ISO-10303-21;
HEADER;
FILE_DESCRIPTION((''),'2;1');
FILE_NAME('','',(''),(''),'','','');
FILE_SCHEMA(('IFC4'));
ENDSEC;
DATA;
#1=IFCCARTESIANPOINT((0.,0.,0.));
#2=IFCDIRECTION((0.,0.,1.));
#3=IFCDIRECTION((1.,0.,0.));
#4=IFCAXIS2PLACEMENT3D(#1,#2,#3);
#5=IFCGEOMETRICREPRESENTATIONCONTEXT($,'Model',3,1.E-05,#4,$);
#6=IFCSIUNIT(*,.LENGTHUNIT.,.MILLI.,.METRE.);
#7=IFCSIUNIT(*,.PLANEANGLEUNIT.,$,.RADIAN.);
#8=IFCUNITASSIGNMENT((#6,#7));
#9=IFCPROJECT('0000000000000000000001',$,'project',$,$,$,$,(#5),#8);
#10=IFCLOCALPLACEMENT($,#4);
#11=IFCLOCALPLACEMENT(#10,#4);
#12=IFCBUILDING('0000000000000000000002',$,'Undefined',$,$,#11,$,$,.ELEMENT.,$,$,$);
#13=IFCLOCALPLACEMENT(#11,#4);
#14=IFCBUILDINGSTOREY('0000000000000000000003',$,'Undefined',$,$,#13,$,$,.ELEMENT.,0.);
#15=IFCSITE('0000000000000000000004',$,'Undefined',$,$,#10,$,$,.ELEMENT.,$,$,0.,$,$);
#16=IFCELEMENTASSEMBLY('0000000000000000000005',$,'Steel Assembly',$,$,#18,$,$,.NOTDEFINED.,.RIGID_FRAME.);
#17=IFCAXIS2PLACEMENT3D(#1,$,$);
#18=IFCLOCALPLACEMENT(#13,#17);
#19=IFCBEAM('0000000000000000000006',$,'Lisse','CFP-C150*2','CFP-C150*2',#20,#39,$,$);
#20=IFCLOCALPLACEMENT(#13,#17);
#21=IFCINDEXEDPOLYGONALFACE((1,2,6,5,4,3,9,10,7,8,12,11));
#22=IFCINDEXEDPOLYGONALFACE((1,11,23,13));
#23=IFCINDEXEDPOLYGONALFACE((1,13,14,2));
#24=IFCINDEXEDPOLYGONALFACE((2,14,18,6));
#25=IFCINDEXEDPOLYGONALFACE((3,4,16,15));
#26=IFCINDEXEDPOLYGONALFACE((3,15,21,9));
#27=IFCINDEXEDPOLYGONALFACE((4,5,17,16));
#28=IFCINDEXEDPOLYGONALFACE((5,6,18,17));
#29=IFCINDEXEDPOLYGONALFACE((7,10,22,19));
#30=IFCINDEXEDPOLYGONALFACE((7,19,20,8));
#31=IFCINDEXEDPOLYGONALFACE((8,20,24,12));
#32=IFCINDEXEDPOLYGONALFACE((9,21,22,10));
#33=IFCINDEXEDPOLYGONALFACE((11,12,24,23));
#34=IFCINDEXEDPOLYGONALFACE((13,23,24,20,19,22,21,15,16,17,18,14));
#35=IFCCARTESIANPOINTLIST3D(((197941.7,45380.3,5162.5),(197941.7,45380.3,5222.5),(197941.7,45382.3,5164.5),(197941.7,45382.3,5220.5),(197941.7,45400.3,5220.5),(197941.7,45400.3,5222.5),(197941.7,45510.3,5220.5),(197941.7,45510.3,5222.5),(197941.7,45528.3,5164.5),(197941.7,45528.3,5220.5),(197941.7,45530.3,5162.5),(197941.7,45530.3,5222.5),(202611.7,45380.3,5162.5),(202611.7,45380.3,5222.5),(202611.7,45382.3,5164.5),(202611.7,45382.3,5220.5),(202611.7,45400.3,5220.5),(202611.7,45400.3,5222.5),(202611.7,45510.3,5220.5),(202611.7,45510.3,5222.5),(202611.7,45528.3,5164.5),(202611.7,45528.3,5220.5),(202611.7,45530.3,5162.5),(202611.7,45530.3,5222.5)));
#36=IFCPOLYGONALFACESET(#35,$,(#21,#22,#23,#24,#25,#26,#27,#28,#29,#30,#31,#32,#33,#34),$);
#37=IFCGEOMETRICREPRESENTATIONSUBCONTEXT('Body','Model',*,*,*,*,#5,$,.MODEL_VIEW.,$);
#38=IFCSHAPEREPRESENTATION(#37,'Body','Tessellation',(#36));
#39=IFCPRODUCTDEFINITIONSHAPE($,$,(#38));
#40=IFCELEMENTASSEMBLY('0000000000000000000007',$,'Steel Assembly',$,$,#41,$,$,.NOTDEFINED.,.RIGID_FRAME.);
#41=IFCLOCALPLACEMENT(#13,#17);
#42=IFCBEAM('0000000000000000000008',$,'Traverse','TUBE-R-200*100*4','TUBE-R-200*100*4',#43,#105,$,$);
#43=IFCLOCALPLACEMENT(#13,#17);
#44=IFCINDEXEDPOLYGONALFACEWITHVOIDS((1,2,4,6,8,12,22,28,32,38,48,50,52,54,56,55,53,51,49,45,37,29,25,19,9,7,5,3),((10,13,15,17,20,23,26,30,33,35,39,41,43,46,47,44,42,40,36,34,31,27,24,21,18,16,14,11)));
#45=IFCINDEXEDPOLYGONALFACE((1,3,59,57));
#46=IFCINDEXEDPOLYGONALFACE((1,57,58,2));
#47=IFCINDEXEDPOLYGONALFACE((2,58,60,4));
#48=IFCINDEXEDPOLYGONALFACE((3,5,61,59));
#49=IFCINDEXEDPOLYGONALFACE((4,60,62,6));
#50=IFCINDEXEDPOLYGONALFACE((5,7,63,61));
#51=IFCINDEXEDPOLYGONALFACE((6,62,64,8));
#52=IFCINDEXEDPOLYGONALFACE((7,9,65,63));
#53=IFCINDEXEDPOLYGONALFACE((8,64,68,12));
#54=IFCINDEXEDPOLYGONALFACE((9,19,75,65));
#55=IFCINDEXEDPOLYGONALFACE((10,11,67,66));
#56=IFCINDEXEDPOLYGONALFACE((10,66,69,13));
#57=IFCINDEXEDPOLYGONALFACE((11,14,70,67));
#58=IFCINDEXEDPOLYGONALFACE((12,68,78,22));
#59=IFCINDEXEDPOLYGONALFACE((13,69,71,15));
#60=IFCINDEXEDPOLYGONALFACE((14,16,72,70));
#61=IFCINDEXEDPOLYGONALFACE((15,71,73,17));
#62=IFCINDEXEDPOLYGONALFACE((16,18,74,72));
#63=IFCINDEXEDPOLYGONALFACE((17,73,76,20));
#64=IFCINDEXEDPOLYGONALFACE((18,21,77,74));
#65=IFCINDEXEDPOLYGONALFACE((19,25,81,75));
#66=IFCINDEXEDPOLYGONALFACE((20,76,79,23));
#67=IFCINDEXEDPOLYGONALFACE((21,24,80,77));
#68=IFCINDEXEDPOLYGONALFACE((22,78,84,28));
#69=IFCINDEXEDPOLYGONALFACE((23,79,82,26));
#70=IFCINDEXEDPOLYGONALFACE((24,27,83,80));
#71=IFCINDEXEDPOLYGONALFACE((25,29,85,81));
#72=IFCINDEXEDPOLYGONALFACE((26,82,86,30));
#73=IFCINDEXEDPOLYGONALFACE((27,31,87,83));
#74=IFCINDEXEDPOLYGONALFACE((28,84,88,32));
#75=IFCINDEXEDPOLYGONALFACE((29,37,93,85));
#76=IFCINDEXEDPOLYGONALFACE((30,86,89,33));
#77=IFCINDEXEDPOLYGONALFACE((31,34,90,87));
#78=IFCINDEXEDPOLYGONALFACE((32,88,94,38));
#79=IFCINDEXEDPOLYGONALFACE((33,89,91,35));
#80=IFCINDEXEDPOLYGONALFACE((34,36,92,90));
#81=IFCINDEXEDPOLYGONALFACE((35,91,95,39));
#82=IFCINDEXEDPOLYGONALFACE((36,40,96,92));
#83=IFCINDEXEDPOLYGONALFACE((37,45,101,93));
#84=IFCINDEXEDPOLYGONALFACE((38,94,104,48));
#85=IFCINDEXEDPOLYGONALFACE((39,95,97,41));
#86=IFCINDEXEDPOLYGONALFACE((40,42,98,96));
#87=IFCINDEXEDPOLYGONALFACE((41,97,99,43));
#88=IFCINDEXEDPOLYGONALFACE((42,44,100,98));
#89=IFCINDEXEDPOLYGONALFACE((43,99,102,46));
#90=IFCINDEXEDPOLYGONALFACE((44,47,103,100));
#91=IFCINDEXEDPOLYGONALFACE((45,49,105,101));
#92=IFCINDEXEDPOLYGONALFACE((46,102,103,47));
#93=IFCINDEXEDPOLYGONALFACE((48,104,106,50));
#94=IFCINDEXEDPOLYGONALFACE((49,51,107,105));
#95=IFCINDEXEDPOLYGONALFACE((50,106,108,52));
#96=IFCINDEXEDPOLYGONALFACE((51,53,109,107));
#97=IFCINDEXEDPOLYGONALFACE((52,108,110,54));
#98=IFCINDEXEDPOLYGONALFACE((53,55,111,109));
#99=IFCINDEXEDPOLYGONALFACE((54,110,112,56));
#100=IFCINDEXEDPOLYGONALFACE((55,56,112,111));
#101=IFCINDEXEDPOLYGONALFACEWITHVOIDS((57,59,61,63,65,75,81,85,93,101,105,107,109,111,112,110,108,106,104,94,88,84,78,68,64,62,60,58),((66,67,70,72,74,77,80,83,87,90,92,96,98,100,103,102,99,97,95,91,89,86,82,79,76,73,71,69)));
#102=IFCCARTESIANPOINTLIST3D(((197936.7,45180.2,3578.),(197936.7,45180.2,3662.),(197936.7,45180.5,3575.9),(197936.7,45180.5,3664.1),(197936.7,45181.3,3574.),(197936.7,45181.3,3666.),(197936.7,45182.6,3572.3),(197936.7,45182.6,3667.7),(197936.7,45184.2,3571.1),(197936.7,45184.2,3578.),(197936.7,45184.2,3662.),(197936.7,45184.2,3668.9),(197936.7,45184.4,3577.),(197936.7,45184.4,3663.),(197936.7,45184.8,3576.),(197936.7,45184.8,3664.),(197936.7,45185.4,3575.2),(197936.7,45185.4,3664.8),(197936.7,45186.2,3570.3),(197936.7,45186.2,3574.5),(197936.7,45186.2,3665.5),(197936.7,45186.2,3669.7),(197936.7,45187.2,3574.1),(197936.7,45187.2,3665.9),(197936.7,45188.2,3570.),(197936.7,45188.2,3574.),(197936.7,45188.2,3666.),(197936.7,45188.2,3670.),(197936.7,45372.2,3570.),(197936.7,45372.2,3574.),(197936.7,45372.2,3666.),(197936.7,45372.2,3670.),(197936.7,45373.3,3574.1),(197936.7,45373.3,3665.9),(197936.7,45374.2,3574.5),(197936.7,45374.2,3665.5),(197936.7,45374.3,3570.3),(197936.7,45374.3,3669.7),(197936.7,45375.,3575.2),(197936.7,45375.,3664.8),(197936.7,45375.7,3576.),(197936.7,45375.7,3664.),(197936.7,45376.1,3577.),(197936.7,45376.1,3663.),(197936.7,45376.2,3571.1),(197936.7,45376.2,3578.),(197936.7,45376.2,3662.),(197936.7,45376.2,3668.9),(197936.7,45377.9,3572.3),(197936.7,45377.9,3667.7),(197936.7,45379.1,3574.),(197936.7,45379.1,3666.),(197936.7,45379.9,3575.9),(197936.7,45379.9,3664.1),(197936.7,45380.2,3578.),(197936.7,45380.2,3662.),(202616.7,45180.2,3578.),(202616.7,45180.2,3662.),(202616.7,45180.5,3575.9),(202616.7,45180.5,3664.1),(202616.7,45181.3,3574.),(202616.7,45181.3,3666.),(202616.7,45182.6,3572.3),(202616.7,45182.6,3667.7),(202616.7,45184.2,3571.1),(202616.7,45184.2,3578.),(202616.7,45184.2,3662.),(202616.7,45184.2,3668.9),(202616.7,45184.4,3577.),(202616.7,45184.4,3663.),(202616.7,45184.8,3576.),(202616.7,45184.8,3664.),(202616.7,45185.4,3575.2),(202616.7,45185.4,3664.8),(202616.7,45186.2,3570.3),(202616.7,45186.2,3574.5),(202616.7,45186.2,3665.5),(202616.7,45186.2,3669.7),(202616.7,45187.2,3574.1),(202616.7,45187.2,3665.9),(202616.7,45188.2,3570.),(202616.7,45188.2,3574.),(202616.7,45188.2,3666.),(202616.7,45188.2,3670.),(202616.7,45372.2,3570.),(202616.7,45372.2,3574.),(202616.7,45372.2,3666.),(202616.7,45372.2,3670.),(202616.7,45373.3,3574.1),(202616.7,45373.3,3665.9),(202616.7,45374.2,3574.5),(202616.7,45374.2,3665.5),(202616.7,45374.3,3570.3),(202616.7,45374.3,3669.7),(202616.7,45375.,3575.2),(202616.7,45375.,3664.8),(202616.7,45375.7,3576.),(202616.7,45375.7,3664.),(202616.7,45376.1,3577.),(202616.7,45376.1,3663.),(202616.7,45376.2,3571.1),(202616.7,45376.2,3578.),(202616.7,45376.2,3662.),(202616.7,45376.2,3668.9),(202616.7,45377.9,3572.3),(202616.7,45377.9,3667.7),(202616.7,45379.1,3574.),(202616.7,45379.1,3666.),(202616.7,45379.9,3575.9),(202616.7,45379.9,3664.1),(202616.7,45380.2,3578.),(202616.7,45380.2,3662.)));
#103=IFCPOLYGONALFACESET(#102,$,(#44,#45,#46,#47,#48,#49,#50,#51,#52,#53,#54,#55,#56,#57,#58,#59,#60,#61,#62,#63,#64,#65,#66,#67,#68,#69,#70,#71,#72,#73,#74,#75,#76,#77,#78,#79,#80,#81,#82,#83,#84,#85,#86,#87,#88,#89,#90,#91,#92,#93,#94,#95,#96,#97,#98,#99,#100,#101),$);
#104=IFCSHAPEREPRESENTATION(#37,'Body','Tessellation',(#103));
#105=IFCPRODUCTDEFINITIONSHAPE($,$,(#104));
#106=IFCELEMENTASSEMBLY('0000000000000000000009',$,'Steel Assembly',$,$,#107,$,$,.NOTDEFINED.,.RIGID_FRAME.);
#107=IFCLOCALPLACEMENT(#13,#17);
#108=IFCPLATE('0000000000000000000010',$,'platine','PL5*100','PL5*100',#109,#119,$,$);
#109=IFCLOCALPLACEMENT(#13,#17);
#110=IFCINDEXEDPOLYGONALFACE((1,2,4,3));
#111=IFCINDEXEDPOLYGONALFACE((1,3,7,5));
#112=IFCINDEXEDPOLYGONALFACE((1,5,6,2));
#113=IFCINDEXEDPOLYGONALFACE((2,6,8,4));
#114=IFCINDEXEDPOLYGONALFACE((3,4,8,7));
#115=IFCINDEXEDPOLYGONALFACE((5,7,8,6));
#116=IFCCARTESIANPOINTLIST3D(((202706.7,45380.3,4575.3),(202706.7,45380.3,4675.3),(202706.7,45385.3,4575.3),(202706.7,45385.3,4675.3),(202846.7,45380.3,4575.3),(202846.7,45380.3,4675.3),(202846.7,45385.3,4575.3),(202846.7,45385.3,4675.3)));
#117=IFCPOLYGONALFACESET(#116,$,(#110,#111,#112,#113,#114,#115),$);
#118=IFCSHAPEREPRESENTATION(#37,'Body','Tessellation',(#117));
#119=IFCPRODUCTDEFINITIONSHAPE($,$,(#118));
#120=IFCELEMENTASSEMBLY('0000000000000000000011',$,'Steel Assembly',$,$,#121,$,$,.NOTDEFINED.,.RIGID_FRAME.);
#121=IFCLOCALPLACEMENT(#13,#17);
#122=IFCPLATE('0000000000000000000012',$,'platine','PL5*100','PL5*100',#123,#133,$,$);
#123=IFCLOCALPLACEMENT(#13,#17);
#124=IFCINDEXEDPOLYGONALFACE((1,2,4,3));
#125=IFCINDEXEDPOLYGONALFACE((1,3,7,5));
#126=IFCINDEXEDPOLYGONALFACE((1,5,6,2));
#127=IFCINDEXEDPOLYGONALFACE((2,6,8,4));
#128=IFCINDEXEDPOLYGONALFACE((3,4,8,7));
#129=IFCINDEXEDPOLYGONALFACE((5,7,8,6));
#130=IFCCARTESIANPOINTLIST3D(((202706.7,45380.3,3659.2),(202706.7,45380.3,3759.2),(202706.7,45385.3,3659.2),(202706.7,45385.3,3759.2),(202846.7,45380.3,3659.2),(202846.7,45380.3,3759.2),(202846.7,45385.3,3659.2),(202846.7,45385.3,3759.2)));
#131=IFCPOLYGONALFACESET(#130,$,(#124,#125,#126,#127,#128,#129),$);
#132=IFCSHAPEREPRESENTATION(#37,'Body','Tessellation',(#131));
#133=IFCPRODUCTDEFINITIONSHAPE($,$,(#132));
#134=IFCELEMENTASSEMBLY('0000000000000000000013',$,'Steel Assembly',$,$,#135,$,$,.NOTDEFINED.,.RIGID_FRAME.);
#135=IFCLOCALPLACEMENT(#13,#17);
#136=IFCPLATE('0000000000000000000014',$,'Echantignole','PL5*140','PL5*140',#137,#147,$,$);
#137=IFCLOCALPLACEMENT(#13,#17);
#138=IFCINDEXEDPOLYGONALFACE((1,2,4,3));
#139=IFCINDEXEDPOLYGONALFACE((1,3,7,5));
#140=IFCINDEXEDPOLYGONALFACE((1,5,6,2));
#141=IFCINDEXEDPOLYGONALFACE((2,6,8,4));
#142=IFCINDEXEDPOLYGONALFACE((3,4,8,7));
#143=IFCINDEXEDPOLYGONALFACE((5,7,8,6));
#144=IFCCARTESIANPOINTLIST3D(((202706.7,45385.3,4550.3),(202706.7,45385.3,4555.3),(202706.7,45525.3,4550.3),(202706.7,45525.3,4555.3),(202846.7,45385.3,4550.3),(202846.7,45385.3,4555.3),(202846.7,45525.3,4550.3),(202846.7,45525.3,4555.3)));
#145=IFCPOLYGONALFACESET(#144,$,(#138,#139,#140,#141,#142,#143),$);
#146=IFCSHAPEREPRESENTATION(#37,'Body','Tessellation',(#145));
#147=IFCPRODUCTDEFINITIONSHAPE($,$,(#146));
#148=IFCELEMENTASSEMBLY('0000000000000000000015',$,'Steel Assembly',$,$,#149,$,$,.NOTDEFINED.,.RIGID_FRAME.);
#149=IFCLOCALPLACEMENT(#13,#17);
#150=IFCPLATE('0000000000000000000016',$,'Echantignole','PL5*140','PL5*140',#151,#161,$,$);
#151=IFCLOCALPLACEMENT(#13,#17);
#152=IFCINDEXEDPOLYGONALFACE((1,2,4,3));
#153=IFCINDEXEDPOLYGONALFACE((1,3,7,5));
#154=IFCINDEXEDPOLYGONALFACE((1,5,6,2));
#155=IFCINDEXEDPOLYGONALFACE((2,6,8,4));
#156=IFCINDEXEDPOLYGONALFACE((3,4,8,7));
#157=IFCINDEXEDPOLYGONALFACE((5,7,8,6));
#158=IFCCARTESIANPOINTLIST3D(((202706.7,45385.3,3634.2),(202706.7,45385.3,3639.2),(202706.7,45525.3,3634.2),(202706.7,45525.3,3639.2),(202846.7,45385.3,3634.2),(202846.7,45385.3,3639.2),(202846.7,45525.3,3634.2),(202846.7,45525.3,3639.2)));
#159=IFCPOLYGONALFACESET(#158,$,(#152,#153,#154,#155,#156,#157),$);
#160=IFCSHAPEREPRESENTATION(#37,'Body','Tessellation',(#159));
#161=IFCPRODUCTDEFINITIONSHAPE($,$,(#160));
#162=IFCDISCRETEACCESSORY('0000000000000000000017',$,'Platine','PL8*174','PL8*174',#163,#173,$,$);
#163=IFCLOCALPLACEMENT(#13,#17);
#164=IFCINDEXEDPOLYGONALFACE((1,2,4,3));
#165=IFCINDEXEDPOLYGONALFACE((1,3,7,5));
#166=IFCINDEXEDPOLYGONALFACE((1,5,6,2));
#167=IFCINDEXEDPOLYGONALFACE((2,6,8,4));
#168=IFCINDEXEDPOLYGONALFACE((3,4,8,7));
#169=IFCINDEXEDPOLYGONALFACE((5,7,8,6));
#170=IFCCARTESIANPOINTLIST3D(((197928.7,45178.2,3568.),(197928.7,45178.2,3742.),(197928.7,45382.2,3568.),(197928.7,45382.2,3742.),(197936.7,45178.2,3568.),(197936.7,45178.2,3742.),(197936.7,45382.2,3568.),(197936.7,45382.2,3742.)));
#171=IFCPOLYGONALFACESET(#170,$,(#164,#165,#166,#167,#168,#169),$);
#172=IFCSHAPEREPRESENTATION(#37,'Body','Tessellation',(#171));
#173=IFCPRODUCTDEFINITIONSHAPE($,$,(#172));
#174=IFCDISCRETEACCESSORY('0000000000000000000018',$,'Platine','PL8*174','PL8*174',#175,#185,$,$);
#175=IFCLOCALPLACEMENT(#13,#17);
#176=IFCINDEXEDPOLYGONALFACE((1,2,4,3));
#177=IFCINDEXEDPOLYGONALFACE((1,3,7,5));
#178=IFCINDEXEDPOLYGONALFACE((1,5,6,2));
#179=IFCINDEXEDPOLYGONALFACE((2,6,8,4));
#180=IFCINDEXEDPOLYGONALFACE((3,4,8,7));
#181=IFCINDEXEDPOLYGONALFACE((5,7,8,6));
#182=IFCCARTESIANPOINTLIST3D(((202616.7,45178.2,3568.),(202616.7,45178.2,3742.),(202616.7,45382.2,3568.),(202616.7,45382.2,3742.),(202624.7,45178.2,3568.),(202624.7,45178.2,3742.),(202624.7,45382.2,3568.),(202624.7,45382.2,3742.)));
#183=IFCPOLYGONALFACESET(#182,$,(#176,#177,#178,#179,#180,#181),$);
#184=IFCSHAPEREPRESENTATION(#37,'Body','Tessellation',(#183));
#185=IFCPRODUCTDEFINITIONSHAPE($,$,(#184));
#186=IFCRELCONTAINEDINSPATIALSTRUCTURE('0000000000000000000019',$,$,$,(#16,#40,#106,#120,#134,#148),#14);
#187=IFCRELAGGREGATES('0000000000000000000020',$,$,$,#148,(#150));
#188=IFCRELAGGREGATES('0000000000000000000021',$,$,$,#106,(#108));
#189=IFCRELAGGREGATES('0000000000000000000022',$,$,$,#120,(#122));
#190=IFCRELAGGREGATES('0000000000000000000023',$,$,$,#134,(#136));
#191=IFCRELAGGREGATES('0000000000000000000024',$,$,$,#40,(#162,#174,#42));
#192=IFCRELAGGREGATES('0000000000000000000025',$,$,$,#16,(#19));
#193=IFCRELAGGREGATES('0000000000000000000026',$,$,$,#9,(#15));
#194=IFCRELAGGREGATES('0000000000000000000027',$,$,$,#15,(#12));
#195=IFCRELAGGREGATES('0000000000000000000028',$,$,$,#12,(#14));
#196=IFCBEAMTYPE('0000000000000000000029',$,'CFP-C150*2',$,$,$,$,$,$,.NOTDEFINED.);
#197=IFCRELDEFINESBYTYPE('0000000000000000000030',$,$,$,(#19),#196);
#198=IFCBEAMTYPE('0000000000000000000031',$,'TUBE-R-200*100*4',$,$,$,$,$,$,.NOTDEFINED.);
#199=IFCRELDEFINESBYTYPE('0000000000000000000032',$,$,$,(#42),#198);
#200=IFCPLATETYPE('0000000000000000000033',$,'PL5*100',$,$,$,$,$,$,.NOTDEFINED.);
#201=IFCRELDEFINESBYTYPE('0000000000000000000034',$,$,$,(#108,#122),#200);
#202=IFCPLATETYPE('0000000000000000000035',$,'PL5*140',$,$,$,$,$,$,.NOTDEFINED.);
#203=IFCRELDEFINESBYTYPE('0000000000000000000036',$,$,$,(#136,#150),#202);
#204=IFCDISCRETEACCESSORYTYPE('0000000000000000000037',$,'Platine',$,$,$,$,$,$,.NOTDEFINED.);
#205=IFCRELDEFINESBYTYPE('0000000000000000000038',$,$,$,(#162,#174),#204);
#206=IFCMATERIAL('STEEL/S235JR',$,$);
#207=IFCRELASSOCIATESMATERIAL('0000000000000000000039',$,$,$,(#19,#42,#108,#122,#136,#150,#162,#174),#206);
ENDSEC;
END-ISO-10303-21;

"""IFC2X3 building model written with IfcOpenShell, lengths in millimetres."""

from ifc_helpers import new_model, si_unit, frame, origin_with_axes, origin_2d_with_axis, place, context, subcontext, project, spatial, polyline, hollow_rectangle, c_section, outline, extrude, material, type_object, element, aggregate, save


model = new_model("IFC2X3")

# Units and contexts
model_context = context("Model", 3, precision=1e-05, world=origin_with_axes())
body_context = subcontext(model_context, "Body", "Model", "MODEL_VIEW")
ifc_project = project(units=[si_unit("LENGTHUNIT", "METRE", prefix="MILLI"), si_unit("PLANEANGLEUNIT", "RADIAN")], contexts=[model_context])

# Site, building, storey
site_placement = place(None, origin_with_axes())
site = spatial("IfcSite", under=ifc_project, at=site_placement, Name="Undefined", CompositionType="ELEMENT", RefElevation=0.0)
building_placement = place(site_placement, origin_with_axes())
building = spatial("IfcBuilding", under=site, at=building_placement, Name="Undefined", CompositionType="ELEMENT")
storey_placement = place(building_placement, origin_with_axes())
storey = spatial("IfcBuildingStorey", under=building, at=storey_placement, Name="Undefined", CompositionType="ELEMENT", Elevation=0.0)

# Element assemblies, beams
assembly_1_placement = place(storey_placement, origin_with_axes())
assembly_1 = element("IfcElementAssembly", 1, at=assembly_1_placement, inside=storey, Name="Steel Assembly", AssemblyPlace="NOTDEFINED", PredefinedType="RIGID_FRAME")
ifc_material_1 = material(Name="STEEL/S235JR")
beam_type_1 = type_object("IfcBeamType", Name="CFP-C150*2", PredefinedType="NOTDEFINED")
beam_1_placement = place(assembly_1_placement, frame((202776.7, 45455.3, 5192.5), z_axis=(0.0, -1.0, 0.0), x_axis=(-1.0, 0.0, 0.0)))
beam_1 = element("IfcBeam", 2, at=beam_1_placement, type_object=beam_type_1, material=ifc_material_1, Name="Lisse", Description="CFP-C150*2", ObjectType="CFP-C150*2", context=body_context, shape_type="SweptSolid", body=[
    extrude(c_section(Depth=150.0, Width=60.0, WallThickness=2.0, Girth=20.0, at=origin_2d_with_axis()), frame((4835.0, 0.0, 0.0), z_axis=(-1.0, 0.0, 0.0), x_axis=(0.0, -1.0, 0.0)), (0.0, 0.0, 1.0), 4670.0),
])
assembly_2_placement = place(storey_placement, origin_with_axes())
assembly_2 = element("IfcElementAssembly", 3, at=assembly_2_placement, inside=storey, Name="Steel Assembly", AssemblyPlace="NOTDEFINED", PredefinedType="RIGID_FRAME")
beam_type_2 = type_object("IfcBeamType", Name="TUBE-R-200*100*4", PredefinedType="NOTDEFINED")
beam_2_placement = place(assembly_2_placement, frame((202626.7, 45280.2, 3620.0), z_axis=(0.0, -1.0, 0.0), x_axis=(-1.0, 0.0, 0.0)))
beam_2 = element("IfcBeam", 4, at=beam_2_placement, type_object=beam_type_2, material=ifc_material_1, Name="Traverse", Description="TUBE-R-200*100*4", ObjectType="TUBE-R-200*100*4", context=body_context, shape_type="SweptSolid", body=[
    extrude(hollow_rectangle(XDim=100.0, YDim=200.0, WallThickness=4.0, InnerFilletRadius=4.0, OuterFilletRadius=8.0, at=origin_2d_with_axis()), frame((4690.0, 0.0, 0.0), z_axis=(-1.0, 0.0, 0.0), x_axis=(0.0, -1.0, 0.0)), (0.0, 0.0, 1.0), 4680.0),
])

# Element assemblies, plates
assembly_3_placement = place(storey_placement, origin_with_axes())
assembly_3 = element("IfcElementAssembly", 5, at=assembly_3_placement, inside=storey, Name="Steel Assembly", AssemblyPlace="NOTDEFINED", PredefinedType="RIGID_FRAME")
plate_type_1 = type_object("IfcPlateType", Name="PL5*100", PredefinedType="NOTDEFINED")
plate_1_placement = place(assembly_3_placement, frame((202706.7, 45382.8, 4675.3), z_axis=(0.0, 1.0, 0.0), x_axis=(1.0, 0.0, 0.0)))
plate_1 = element("IfcPlate", 6, at=plate_1_placement, type_object=plate_type_1, material=ifc_material_1, Name="platine", Description="PL5*100", ObjectType="PL5*100", context=body_context, shape_type="SweptSolid", body=[
    extrude(outline(polyline([(0.0, 0.0), (140.0, 0.0), (140.0, 100.0), (0.0, 100.0), (0.0, 0.0)])), frame((0.0, 0.0, -2.5), z_axis=(0.0, 0.0, 1.0), x_axis=(1.0, 0.0, 0.0)), (0.0, 0.0, 1.0), 5.0),
])
assembly_4_placement = place(storey_placement, origin_with_axes())
assembly_4 = element("IfcElementAssembly", 7, at=assembly_4_placement, inside=storey, Name="Steel Assembly", AssemblyPlace="NOTDEFINED", PredefinedType="RIGID_FRAME")
plate_2_placement = place(assembly_4_placement, frame((202706.7, 45382.8, 3759.2), z_axis=(0.0, 1.0, 0.0), x_axis=(1.0, 0.0, 0.0)))
plate_2 = element("IfcPlate", 8, at=plate_2_placement, type_object=plate_type_1, material=ifc_material_1, Name="platine", Description="PL5*100", ObjectType="PL5*100", context=body_context, shape_type="SweptSolid", body=[
    extrude(outline(polyline([(0.0, 0.0), (140.0, 0.0), (140.0, 100.0), (0.0, 100.0), (0.0, 0.0)])), frame((0.0, 0.0, -2.5), z_axis=(0.0, 0.0, 1.0), x_axis=(1.0, 0.0, 0.0)), (0.0, 0.0, 1.0), 5.0),
])
assembly_5_placement = place(storey_placement, origin_with_axes())
assembly_5 = element("IfcElementAssembly", 9, at=assembly_5_placement, inside=storey, Name="Steel Assembly", AssemblyPlace="NOTDEFINED", PredefinedType="RIGID_FRAME")
plate_type_2 = type_object("IfcPlateType", Name="PL5*140", PredefinedType="NOTDEFINED")
plate_3_placement = place(assembly_5_placement, frame((202706.7, 45385.3, 4552.8), z_axis=(0.0, 0.0, 1.0), x_axis=(1.0, 0.0, 0.0)))
plate_3 = element("IfcPlate", 10, at=plate_3_placement, type_object=plate_type_2, material=ifc_material_1, Name="Echantignole", Description="PL5*140", ObjectType="PL5*140", context=body_context, shape_type="SweptSolid", body=[
    extrude(outline(polyline([(0.0, 0.0), (140.0, 0.0), (140.0, 140.0), (0.0, 140.0), (0.0, 0.0)])), frame((0.0, 0.0, -2.5), z_axis=(0.0, 0.0, 1.0), x_axis=(1.0, 0.0, 0.0)), (0.0, 0.0, 1.0), 5.0),
])
assembly_6_placement = place(storey_placement, origin_with_axes())
assembly_6 = element("IfcElementAssembly", 11, at=assembly_6_placement, inside=storey, Name="Steel Assembly", AssemblyPlace="NOTDEFINED", PredefinedType="RIGID_FRAME")
plate_4_placement = place(assembly_6_placement, frame((202706.7, 45385.3, 3636.7), z_axis=(0.0, 0.0, 1.0), x_axis=(1.0, 0.0, 0.0)))
plate_4 = element("IfcPlate", 12, at=plate_4_placement, type_object=plate_type_2, material=ifc_material_1, Name="Echantignole", Description="PL5*140", ObjectType="PL5*140", context=body_context, shape_type="SweptSolid", body=[
    extrude(outline(polyline([(0.0, 0.0), (140.0, 0.0), (140.0, 140.0), (0.0, 140.0), (0.0, 0.0)])), frame((0.0, 0.0, -2.5), z_axis=(0.0, 0.0, 1.0), x_axis=(1.0, 0.0, 0.0)), (0.0, 0.0, 1.0), 5.0),
])
aggregate(assembly_6, [plate_4])

# Discrete accessories
discrete_accessory_type_1 = type_object("IfcDiscreteAccessoryType", Name="Platine")
discrete_accessory_1_placement = place(assembly_2_placement, frame((197932.7, 45382.2, 3655.0), z_axis=(1.0, 0.0, 0.0), x_axis=(0.0, -1.0, 0.0)))
discrete_accessory_1 = element("IfcDiscreteAccessory", 13, at=discrete_accessory_1_placement, type_object=discrete_accessory_type_1, material=ifc_material_1, Name="Platine", Description="PL8*174", ObjectType="PL8*174", context=body_context, shape_type="SweptSolid", body=[
    extrude(outline(polyline([(204.0, -87.0), (0.0, -87.0), (0.0, 87.0), (204.0, 87.0), (204.0, -87.0)])), frame((0.0, 0.0, -4.0), z_axis=(0.0, 0.0, 1.0), x_axis=(1.0, 0.0, 0.0)), (0.0, 0.0, 1.0), 8.0),
])
discrete_accessory_2_placement = place(assembly_2_placement, frame((202620.7, 45178.2, 3655.0), z_axis=(-1.0, 0.0, 0.0), x_axis=(0.0, 1.0, 0.0)))
discrete_accessory_2 = element("IfcDiscreteAccessory", 14, at=discrete_accessory_2_placement, type_object=discrete_accessory_type_1, material=ifc_material_1, Name="Platine", Description="PL8*174", ObjectType="PL8*174", context=body_context, shape_type="SweptSolid", body=[
    extrude(outline(polyline([(204.0, 87.0), (204.0, -87.0), (0.0, -87.0), (0.0, 87.0), (204.0, 87.0)])), frame((0.0, 0.0, -4.0), z_axis=(0.0, 0.0, 1.0), x_axis=(1.0, 0.0, 0.0)), (0.0, 0.0, 1.0), 8.0),
])

aggregate(assembly_3, [plate_1])
aggregate(assembly_4, [plate_2])
aggregate(assembly_5, [plate_3])

aggregate(assembly_2, [discrete_accessory_1, discrete_accessory_2, beam_2])

aggregate(assembly_1, [beam_1])

save(model, "model.ifc")
